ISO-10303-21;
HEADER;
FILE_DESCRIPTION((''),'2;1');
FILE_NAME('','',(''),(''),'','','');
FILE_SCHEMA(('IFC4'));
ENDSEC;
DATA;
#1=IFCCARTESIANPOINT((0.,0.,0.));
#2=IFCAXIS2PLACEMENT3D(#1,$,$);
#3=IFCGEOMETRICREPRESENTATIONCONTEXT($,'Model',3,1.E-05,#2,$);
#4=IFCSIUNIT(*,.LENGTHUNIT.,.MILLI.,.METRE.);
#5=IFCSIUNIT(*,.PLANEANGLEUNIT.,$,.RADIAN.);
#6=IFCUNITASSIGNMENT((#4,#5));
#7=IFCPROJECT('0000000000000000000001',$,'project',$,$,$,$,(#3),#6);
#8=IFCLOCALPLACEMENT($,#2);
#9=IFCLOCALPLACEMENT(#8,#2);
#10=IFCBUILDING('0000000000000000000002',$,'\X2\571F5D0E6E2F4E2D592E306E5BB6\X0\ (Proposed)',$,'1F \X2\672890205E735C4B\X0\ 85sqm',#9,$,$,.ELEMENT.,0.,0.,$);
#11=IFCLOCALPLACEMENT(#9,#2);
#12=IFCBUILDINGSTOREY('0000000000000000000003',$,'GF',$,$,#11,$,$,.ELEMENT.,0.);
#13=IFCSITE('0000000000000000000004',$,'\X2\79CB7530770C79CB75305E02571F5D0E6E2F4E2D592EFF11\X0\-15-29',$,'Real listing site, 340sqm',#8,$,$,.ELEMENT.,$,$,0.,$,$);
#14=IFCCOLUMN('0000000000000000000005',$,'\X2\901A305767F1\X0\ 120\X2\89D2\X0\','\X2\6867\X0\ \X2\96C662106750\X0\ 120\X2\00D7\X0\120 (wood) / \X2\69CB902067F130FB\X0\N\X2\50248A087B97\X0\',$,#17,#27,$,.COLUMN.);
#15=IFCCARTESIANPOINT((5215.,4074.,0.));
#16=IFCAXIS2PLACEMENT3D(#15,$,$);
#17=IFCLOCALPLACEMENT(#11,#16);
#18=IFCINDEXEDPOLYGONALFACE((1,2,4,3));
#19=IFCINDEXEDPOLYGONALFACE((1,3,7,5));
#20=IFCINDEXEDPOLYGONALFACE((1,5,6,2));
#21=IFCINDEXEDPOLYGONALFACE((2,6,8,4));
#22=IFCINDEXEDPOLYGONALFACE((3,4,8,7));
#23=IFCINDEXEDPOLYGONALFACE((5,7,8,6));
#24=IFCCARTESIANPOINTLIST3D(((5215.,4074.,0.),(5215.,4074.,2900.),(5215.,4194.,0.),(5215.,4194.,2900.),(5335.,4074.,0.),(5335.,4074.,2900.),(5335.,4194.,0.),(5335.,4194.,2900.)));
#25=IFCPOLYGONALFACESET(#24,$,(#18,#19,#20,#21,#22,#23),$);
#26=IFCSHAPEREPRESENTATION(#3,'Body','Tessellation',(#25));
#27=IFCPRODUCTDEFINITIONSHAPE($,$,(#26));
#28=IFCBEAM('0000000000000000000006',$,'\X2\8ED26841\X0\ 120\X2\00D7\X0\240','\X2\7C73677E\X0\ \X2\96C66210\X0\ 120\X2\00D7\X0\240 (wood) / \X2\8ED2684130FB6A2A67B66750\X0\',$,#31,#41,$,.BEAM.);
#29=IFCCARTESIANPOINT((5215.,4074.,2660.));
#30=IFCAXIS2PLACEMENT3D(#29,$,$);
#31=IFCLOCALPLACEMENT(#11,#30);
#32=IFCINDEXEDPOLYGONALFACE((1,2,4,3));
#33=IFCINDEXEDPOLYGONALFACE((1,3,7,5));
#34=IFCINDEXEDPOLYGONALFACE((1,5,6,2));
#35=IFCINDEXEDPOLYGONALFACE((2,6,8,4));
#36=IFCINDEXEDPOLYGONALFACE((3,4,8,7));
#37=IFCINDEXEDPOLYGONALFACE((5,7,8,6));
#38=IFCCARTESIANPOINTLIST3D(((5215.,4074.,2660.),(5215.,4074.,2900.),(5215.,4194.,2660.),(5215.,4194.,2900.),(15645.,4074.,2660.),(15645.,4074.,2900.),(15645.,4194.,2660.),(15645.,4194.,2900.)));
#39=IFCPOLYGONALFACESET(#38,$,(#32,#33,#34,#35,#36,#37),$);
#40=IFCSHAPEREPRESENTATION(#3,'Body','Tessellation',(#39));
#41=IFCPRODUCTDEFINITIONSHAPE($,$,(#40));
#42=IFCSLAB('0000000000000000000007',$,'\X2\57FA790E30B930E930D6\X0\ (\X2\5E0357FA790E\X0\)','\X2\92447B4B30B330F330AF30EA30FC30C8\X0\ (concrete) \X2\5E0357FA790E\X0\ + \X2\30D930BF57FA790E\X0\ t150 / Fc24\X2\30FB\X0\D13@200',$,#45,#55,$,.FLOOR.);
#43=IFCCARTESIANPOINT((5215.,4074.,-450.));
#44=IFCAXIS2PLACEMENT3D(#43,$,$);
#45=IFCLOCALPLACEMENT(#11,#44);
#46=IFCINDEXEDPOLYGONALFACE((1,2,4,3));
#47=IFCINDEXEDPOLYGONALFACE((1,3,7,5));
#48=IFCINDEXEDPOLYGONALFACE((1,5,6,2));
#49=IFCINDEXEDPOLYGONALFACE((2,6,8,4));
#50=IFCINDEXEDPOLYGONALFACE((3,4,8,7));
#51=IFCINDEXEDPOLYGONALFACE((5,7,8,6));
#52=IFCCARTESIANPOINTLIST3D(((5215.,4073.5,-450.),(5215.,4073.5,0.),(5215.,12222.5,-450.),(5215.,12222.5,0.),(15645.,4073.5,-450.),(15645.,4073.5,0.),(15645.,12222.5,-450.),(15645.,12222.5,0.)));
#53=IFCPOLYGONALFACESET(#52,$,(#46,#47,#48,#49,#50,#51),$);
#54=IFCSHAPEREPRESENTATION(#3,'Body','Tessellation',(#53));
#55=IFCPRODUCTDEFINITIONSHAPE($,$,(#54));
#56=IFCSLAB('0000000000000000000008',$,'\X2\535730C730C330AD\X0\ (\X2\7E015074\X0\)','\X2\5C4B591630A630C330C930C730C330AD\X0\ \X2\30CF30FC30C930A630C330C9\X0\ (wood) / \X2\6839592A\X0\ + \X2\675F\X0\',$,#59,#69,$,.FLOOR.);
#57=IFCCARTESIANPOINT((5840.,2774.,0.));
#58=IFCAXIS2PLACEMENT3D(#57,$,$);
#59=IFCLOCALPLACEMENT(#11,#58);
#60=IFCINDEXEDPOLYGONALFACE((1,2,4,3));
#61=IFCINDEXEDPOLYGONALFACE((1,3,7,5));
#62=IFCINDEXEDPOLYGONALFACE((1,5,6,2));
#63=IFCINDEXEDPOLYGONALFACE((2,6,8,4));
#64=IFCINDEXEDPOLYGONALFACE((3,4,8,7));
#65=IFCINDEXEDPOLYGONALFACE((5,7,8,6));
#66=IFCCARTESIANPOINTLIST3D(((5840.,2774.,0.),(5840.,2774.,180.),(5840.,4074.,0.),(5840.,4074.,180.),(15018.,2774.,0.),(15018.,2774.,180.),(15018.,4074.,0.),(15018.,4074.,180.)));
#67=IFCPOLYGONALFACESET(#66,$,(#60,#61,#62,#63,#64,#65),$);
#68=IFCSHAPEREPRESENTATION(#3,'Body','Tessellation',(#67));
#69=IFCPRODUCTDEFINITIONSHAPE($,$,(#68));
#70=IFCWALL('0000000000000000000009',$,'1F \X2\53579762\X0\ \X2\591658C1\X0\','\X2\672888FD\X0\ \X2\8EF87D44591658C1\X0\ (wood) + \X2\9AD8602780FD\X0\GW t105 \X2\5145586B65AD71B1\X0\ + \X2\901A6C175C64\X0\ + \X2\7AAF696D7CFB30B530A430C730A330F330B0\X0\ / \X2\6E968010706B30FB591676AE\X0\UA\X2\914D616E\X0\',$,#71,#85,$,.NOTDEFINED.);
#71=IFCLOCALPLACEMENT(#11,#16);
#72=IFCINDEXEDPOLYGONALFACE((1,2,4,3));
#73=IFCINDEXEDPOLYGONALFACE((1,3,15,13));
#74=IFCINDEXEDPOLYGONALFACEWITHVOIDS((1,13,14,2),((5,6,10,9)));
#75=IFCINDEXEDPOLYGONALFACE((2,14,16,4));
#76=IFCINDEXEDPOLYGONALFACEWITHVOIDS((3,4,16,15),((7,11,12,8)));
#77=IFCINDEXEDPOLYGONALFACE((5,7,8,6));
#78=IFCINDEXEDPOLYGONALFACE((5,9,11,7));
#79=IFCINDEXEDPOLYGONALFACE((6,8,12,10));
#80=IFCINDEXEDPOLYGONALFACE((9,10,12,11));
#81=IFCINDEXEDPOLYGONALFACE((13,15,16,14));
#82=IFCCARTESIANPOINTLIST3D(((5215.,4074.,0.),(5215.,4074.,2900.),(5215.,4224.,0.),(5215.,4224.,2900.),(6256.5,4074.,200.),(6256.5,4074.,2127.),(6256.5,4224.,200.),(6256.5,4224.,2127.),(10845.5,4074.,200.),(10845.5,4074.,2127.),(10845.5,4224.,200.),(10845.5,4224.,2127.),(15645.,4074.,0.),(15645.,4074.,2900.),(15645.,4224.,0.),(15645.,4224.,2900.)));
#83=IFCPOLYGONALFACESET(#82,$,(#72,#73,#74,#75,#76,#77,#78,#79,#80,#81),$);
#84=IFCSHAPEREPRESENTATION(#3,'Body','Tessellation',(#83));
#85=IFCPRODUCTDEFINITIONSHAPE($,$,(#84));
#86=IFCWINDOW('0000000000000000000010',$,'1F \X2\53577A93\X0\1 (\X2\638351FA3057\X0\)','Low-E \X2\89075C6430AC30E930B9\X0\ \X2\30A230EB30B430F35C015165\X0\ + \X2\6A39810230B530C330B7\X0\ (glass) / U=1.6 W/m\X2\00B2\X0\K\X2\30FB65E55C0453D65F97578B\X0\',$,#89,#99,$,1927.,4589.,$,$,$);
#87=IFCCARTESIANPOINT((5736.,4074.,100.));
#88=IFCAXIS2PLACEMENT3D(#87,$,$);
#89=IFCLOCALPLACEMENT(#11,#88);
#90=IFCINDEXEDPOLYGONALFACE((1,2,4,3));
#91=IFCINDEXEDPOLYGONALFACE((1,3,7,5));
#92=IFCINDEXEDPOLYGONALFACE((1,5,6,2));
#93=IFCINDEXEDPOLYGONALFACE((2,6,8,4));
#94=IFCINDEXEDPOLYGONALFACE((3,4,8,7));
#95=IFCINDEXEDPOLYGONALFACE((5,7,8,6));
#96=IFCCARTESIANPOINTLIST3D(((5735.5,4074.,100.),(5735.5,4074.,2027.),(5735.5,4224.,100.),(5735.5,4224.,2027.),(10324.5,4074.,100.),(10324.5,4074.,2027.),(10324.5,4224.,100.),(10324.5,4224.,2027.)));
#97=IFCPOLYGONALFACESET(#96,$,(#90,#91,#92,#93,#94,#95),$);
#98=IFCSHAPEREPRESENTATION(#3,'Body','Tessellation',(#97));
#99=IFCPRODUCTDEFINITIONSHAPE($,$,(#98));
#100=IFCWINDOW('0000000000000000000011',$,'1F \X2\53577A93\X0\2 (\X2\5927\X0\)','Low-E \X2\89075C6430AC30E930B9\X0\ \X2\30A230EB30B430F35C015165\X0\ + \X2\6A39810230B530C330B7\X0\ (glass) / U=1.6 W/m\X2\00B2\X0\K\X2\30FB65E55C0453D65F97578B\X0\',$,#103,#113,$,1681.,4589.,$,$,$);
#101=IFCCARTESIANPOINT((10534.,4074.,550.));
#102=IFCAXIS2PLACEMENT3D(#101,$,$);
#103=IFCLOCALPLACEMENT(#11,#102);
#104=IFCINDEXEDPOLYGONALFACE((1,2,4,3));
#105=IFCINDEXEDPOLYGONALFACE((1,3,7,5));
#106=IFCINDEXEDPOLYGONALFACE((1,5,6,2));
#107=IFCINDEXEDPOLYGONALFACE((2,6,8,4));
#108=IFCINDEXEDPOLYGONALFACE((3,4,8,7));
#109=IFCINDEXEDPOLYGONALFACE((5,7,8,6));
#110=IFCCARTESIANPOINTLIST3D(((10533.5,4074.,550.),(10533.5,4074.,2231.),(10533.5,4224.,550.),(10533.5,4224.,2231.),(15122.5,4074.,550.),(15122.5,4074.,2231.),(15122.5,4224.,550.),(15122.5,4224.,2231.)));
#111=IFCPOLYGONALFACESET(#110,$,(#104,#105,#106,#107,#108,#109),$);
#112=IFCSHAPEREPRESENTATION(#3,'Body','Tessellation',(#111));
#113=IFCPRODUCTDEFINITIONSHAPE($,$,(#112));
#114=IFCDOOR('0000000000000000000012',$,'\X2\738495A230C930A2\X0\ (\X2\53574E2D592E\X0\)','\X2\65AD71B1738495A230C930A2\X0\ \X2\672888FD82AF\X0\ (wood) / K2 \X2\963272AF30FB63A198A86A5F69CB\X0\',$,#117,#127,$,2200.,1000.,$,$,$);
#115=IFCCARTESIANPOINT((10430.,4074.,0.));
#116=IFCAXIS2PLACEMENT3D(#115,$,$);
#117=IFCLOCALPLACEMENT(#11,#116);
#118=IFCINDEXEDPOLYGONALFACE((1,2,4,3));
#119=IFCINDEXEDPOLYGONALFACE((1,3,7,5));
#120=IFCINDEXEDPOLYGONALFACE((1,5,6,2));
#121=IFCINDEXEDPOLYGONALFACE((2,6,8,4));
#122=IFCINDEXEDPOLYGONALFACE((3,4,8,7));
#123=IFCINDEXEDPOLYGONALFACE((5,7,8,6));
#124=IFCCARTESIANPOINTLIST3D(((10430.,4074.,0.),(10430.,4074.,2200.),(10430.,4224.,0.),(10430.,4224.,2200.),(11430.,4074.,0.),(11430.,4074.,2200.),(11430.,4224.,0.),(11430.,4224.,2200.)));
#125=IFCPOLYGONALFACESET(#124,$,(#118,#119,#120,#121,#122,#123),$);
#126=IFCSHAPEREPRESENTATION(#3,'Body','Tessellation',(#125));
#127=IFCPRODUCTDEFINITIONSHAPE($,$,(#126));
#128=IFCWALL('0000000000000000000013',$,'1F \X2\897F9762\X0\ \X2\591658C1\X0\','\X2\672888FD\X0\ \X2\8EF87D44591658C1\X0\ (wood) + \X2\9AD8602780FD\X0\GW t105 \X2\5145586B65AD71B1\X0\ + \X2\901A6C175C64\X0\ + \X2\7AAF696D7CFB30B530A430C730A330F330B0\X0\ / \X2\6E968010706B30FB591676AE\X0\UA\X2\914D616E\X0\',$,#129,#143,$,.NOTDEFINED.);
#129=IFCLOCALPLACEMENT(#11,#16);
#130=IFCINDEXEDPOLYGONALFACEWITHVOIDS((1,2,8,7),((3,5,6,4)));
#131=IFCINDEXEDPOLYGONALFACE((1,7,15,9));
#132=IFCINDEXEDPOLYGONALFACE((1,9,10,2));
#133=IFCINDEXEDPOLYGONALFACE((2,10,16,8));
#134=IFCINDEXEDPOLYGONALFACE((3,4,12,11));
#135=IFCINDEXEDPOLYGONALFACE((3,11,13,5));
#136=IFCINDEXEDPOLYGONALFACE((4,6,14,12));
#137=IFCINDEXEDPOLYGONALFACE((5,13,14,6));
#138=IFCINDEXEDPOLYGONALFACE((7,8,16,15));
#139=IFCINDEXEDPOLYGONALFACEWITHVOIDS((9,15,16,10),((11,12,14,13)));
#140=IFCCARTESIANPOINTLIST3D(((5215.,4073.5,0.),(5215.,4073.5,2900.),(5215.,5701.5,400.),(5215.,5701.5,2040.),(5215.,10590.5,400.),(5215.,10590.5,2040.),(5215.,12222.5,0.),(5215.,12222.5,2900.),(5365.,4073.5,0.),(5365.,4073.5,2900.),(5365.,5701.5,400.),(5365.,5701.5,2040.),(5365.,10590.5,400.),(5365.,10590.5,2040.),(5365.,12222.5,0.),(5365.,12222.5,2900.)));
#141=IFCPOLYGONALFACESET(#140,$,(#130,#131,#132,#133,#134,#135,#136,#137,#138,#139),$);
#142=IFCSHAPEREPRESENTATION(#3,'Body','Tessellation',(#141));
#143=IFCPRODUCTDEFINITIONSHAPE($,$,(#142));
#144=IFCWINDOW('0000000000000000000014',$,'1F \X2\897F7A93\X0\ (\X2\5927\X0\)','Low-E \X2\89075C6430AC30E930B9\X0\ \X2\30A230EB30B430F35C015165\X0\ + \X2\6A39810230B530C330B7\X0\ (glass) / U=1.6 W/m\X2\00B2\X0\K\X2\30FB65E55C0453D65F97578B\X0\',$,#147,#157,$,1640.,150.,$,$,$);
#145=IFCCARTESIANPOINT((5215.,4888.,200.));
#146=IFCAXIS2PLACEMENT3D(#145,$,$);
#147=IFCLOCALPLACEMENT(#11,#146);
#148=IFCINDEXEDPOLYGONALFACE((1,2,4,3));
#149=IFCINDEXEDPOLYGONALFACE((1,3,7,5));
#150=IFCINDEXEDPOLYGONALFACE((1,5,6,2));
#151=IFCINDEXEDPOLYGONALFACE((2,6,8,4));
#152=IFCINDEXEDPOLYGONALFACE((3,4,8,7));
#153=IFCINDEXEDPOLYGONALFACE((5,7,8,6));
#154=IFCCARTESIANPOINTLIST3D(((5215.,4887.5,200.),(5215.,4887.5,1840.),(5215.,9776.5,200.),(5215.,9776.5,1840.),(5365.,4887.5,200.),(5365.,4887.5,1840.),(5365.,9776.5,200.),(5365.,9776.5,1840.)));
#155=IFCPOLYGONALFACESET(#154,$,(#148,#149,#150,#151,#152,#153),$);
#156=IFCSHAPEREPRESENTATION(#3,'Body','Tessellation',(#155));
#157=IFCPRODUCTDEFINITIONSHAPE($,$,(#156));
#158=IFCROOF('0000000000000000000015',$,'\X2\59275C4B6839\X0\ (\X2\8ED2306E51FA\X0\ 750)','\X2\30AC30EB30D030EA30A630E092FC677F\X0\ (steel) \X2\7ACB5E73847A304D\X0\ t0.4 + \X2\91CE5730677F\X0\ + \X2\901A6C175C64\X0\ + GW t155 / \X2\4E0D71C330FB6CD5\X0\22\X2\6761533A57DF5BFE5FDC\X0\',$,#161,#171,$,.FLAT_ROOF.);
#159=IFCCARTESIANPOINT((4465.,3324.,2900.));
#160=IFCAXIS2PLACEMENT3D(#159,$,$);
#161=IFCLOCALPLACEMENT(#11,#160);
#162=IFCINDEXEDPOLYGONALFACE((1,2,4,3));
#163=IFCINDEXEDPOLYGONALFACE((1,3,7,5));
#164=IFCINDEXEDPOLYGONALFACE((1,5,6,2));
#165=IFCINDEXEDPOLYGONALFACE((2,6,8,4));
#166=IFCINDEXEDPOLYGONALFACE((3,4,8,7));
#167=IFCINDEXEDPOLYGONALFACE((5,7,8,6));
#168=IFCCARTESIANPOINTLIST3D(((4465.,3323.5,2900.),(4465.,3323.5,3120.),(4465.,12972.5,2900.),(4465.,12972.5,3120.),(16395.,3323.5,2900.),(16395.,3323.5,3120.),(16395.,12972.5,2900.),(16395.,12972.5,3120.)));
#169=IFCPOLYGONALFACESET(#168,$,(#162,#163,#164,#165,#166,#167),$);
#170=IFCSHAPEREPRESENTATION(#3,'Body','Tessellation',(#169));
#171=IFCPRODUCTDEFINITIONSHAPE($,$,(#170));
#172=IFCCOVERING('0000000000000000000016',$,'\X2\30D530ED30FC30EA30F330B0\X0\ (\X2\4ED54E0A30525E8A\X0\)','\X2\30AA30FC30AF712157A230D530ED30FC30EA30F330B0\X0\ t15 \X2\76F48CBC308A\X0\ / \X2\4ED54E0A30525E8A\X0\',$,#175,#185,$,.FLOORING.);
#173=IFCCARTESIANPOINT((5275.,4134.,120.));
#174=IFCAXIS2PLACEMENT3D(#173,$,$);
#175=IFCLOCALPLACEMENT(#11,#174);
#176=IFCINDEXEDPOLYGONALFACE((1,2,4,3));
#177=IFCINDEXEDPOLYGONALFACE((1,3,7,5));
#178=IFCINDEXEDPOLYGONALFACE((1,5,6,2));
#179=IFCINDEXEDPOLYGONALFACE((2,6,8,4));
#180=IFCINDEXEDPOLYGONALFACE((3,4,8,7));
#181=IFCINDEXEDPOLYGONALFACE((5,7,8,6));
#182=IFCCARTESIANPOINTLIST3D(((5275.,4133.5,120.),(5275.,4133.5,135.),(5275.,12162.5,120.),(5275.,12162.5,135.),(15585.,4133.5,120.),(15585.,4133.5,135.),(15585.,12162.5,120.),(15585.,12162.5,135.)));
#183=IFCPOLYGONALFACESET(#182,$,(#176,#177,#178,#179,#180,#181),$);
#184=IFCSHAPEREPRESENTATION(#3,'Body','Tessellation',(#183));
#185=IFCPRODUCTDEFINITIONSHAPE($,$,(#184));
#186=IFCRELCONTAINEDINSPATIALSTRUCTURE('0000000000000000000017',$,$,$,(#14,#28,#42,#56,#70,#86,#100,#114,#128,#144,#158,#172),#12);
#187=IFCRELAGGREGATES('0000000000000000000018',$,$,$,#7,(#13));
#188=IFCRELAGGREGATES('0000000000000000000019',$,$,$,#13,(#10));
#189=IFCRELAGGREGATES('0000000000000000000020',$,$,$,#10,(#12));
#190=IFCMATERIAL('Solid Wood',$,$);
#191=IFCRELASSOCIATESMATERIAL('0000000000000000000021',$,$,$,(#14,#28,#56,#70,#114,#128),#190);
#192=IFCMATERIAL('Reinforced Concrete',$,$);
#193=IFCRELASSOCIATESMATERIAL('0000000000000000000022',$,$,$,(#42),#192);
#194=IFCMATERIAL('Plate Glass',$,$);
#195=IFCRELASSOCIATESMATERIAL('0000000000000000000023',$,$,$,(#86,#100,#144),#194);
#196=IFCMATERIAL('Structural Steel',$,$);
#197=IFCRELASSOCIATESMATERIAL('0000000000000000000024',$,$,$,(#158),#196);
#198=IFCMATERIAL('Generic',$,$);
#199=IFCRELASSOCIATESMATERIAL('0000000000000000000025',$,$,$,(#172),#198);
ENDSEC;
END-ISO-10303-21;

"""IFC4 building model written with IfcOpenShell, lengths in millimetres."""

from ifc_helpers import new_model, si_unit, frame, frame_2d, origin, place, context, project, spatial, rectangle, extrude, material, element, fill, save


model = new_model("IFC4")

# Units and contexts
model_context = context("Model", 3, precision=1e-05, world=origin())
ifc_project = project(units=[si_unit("LENGTHUNIT", "METRE", prefix="MILLI"), si_unit("PLANEANGLEUNIT", "RADIAN")], contexts=[model_context])

# Site, building, storey
site_placement = place(None, origin())
site = spatial("IfcSite", under=ifc_project, at=site_placement, Name="秋田県秋田市土崎港中央１-15-29", ObjectType="Real listing site, 340sqm", CompositionType="ELEMENT", RefElevation=0.0)
building_placement = place(site_placement, origin())
building = spatial("IfcBuilding", under=site, at=building_placement, Name="土崎港中央の家 (Proposed)", ObjectType="1F 木造平屋 85sqm", CompositionType="ELEMENT", ElevationOfRefHeight=0.0, ElevationOfTerrain=0.0)
storey_placement = place(building_placement, origin())
storey = spatial("IfcBuildingStorey", under=building, at=storey_placement, Name="GF", CompositionType="ELEMENT", Elevation=0.0)

# Column
ifc_material_1 = material(Name="Solid Wood")
column_1_placement = place(storey_placement, frame((5215.0, 4074.0, 0.0)))
element("IfcColumn", 1, at=column_1_placement, inside=storey, material=ifc_material_1, Name="通し柱 120角", Description="桧 集成材 120×120 (wood) / 構造柱・N値計算", PredefinedType="COLUMN", context=model_context, shape_type="SweptSolid", body=[
    extrude(rectangle(XDim=120.0, YDim=120.0, at=frame_2d((60.0, 60.0))), frame((5215.0, 4074.0, 0.0)), (0.0, 0.0, 1.0), 2900.0),
])

# Beam
beam_1_placement = place(storey_placement, frame((5215.0, 4074.0, 2660.0)))
element("IfcBeam", 2, at=beam_1_placement, inside=storey, material=ifc_material_1, Name="軒桁 120×240", Description="米松 集成 120×240 (wood) / 軒桁・横架材", PredefinedType="BEAM", context=model_context, shape_type="SweptSolid", body=[
    extrude(rectangle(XDim=10430.0, YDim=120.0, at=frame_2d((5215.0, 60.0))), frame((5215.0, 4074.0, 2660.0)), (0.0, 0.0, 1.0), 240.0),
])

# Slabs
ifc_material_2 = material(Name="Reinforced Concrete")
slab_1_placement = place(storey_placement, frame((5215.0, 4074.0, -450.0)))
element("IfcSlab", 3, at=slab_1_placement, inside=storey, material=ifc_material_2, Name="基礎スラブ (布基礎)", Description="鉄筋コンクリート (concrete) 布基礎 + ベタ基礎 t150 / Fc24・D13@200", PredefinedType="FLOOR", context=model_context, shape_type="SweptSolid", body=[
    extrude(rectangle(XDim=10430.0, YDim=8149.0, at=frame_2d((5215.0, 4074.0))), frame((5215.0, 4074.0, -450.0)), (0.0, 0.0, 1.0), 450.0),
])
slab_2_placement = place(storey_placement, frame((5840.0, 2774.0, 0.0)))
element("IfcSlab", 4, at=slab_2_placement, inside=storey, material=ifc_material_1, Name="南デッキ (縁側)", Description="屋外ウッドデッキ ハードウッド (wood) / 根太 + 束", PredefinedType="FLOOR", context=model_context, shape_type="SweptSolid", body=[
    extrude(rectangle(XDim=9178.0, YDim=1300.0, at=frame_2d((4589.0, 650.0))), frame((5840.0, 2774.0, 0.0)), (0.0, 0.0, 1.0), 180.0),
])

# Wall, openings, windows, door
wall_1_placement = place(storey_placement, frame((5215.0, 4074.0, 0.0)))
wall_1 = element("IfcWall", 5, at=wall_1_placement, inside=storey, material=ifc_material_1, Name="1F 南面 外壁", Description="木製 軸組外壁 (wood) + 高性能GW t105 充填断熱 + 通気層 + 窯業系サイディング / 準耐火・外皮UA配慮", PredefinedType="NOTDEFINED", context=model_context, shape_type="SweptSolid", body=[
    extrude(rectangle(XDim=10430.0, YDim=150.0, at=frame_2d((5215.0, 75.0))), frame((5215.0, 4074.0, 0.0)), (0.0, 0.0, 1.0), 2900.0),
])
opening_1_placement = place(storey_placement, frame((5736.0, 4074.0, 100.0)))
opening_1 = element("IfcOpeningElement", 6, at=opening_1_placement, cuts=wall_1, PredefinedType="NOTDEFINED", context=model_context, shape_type="SweptSolid", body=[
    extrude(rectangle(XDim=4589.0, YDim=150.0, at=frame_2d((2294.0, 75.0))), frame((5736.0, 4074.0, 100.0)), (0.0, 0.0, 1.0), 1927.0),
])
opening_2_placement = place(storey_placement, frame((10534.0, 4074.0, 550.0)))
opening_2 = element("IfcOpeningElement", 7, at=opening_2_placement, cuts=wall_1, PredefinedType="NOTDEFINED", context=model_context, shape_type="SweptSolid", body=[
    extrude(rectangle(XDim=4589.0, YDim=150.0, at=frame_2d((2294.0, 75.0))), frame((10534.0, 4074.0, 550.0)), (0.0, 0.0, 1.0), 1681.0),
])
opening_3_placement = place(storey_placement, frame((10430.0, 4074.0, 0.0)))
opening_3 = element("IfcOpeningElement", 8, at=opening_3_placement, cuts=wall_1, PredefinedType="NOTDEFINED", context=model_context, shape_type="SweptSolid", body=[
    extrude(rectangle(XDim=1000.0, YDim=150.0, at=frame_2d((500.0, 75.0))), frame((10430.0, 4074.0, 0.0)), (0.0, 0.0, 1.0), 2200.0),
])
ifc_material_3 = material(Name="Plate Glass")
window_1_placement = place(storey_placement, frame((5736.0, 4074.0, 100.0)))
window_1 = element("IfcWindow", 9, at=window_1_placement, inside=storey, material=ifc_material_3, Name="1F 南窓1 (掃出し)", Description="Low-E 複層ガラス アルゴン封入 + 樹脂サッシ (glass) / U=1.6 W/m²K・日射取得型", OverallHeight=1927.0, OverallWidth=4589.0, context=model_context, shape_type="SweptSolid", body=[
    extrude(rectangle(XDim=4589.0, YDim=150.0, at=frame_2d((2294.0, 75.0))), frame((5736.0, 4074.0, 100.0)), (0.0, 0.0, 1.0), 1927.0),
])
fill(opening_1, window_1)
window_2_placement = place(storey_placement, frame((10534.0, 4074.0, 550.0)))
window_2 = element("IfcWindow", 10, at=window_2_placement, inside=storey, material=ifc_material_3, Name="1F 南窓2 (大)", Description="Low-E 複層ガラス アルゴン封入 + 樹脂サッシ (glass) / U=1.6 W/m²K・日射取得型", OverallHeight=1681.0, OverallWidth=4589.0, context=model_context, shape_type="SweptSolid", body=[
    extrude(rectangle(XDim=4589.0, YDim=150.0, at=frame_2d((2294.0, 75.0))), frame((10534.0, 4074.0, 550.0)), (0.0, 0.0, 1.0), 1681.0),
])
fill(opening_2, window_2)
door_placement = place(storey_placement, frame((10430.0, 4074.0, 0.0)))
door = element("IfcDoor", 11, at=door_placement, inside=storey, material=ifc_material_1, Name="玄関ドア (南中央)", Description="断熱玄関ドア 木製芯 (wood) / K2 防犯・採風機構", OverallHeight=2200.0, OverallWidth=1000.0, context=model_context, shape_type="SweptSolid", body=[
    extrude(rectangle(XDim=1000.0, YDim=150.0, at=frame_2d((500.0, 75.0))), frame((10430.0, 4074.0, 0.0)), (0.0, 0.0, 1.0), 2200.0),
])
fill(opening_3, door)

# Wall, opening, window
wall_2_placement = place(storey_placement, frame((5215.0, 4074.0, 0.0)))
wall_2 = element("IfcWall", 12, at=wall_2_placement, inside=storey, material=ifc_material_1, Name="1F 西面 外壁", Description="木製 軸組外壁 (wood) + 高性能GW t105 充填断熱 + 通気層 + 窯業系サイディング / 準耐火・外皮UA配慮", PredefinedType="NOTDEFINED", context=model_context, shape_type="SweptSolid", body=[
    extrude(rectangle(XDim=150.0, YDim=8149.0, at=frame_2d((75.0, 4074.0))), frame((5215.0, 4074.0, 0.0)), (0.0, 0.0, 1.0), 2900.0),
])
opening_4_placement = place(storey_placement, frame((5215.0, 4888.0, 200.0)))
opening_4 = element("IfcOpeningElement", 13, at=opening_4_placement, cuts=wall_2, PredefinedType="NOTDEFINED", context=model_context, shape_type="SweptSolid", body=[
    extrude(rectangle(XDim=150.0, YDim=4889.0, at=frame_2d((75.0, 2444.0))), frame((5215.0, 4888.0, 200.0)), (0.0, 0.0, 1.0), 1640.0),
])
window_3_placement = place(storey_placement, frame((5215.0, 4888.0, 200.0)))
window_3 = element("IfcWindow", 14, at=window_3_placement, inside=storey, material=ifc_material_3, Name="1F 西窓 (大)", Description="Low-E 複層ガラス アルゴン封入 + 樹脂サッシ (glass) / U=1.6 W/m²K・日射取得型", OverallHeight=1640.0, OverallWidth=150.0, context=model_context, shape_type="SweptSolid", body=[
    extrude(rectangle(XDim=150.0, YDim=4889.0, at=frame_2d((75.0, 2444.0))), frame((5215.0, 4888.0, 200.0)), (0.0, 0.0, 1.0), 1640.0),
])
fill(opening_4, window_3)

# Roof
ifc_material_4 = material(Name="Structural Steel")
roof_placement = place(storey_placement, frame((4465.0, 3324.0, 2900.0)))
element("IfcRoof", 15, at=roof_placement, inside=storey, material=ifc_material_4, Name="大屋根 (軒の出 750)", Description="ガルバリウム鋼板 (steel) 立平葺き t0.4 + 野地板 + 通気層 + GW t155 / 不燃・法22条区域対応", PredefinedType="FLAT_ROOF", context=model_context, shape_type="SweptSolid", body=[
    extrude(rectangle(XDim=11930.0, YDim=9649.0, at=frame_2d((5965.0, 4824.0))), frame((4465.0, 3324.0, 2900.0)), (0.0, 0.0, 1.0), 220.0),
])

# Covering
ifc_material_5 = material(Name="Generic")
covering_1_placement = place(storey_placement, frame((5275.0, 4134.0, 120.0)))
element("IfcCovering", 16, at=covering_1_placement, inside=storey, material=ifc_material_5, Name="フローリング (仕上げ床)", Description="オーク無垢フローリング t15 直貼り / 仕上げ床", PredefinedType="FLOORING", context=model_context, shape_type="SweptSolid", body=[
    extrude(rectangle(XDim=10310.0, YDim=8029.0, at=frame_2d((5155.0, 4014.0))), frame((5275.0, 4134.0, 120.0)), (0.0, 0.0, 1.0), 15.0),
])

save(model, "model.ifc")
